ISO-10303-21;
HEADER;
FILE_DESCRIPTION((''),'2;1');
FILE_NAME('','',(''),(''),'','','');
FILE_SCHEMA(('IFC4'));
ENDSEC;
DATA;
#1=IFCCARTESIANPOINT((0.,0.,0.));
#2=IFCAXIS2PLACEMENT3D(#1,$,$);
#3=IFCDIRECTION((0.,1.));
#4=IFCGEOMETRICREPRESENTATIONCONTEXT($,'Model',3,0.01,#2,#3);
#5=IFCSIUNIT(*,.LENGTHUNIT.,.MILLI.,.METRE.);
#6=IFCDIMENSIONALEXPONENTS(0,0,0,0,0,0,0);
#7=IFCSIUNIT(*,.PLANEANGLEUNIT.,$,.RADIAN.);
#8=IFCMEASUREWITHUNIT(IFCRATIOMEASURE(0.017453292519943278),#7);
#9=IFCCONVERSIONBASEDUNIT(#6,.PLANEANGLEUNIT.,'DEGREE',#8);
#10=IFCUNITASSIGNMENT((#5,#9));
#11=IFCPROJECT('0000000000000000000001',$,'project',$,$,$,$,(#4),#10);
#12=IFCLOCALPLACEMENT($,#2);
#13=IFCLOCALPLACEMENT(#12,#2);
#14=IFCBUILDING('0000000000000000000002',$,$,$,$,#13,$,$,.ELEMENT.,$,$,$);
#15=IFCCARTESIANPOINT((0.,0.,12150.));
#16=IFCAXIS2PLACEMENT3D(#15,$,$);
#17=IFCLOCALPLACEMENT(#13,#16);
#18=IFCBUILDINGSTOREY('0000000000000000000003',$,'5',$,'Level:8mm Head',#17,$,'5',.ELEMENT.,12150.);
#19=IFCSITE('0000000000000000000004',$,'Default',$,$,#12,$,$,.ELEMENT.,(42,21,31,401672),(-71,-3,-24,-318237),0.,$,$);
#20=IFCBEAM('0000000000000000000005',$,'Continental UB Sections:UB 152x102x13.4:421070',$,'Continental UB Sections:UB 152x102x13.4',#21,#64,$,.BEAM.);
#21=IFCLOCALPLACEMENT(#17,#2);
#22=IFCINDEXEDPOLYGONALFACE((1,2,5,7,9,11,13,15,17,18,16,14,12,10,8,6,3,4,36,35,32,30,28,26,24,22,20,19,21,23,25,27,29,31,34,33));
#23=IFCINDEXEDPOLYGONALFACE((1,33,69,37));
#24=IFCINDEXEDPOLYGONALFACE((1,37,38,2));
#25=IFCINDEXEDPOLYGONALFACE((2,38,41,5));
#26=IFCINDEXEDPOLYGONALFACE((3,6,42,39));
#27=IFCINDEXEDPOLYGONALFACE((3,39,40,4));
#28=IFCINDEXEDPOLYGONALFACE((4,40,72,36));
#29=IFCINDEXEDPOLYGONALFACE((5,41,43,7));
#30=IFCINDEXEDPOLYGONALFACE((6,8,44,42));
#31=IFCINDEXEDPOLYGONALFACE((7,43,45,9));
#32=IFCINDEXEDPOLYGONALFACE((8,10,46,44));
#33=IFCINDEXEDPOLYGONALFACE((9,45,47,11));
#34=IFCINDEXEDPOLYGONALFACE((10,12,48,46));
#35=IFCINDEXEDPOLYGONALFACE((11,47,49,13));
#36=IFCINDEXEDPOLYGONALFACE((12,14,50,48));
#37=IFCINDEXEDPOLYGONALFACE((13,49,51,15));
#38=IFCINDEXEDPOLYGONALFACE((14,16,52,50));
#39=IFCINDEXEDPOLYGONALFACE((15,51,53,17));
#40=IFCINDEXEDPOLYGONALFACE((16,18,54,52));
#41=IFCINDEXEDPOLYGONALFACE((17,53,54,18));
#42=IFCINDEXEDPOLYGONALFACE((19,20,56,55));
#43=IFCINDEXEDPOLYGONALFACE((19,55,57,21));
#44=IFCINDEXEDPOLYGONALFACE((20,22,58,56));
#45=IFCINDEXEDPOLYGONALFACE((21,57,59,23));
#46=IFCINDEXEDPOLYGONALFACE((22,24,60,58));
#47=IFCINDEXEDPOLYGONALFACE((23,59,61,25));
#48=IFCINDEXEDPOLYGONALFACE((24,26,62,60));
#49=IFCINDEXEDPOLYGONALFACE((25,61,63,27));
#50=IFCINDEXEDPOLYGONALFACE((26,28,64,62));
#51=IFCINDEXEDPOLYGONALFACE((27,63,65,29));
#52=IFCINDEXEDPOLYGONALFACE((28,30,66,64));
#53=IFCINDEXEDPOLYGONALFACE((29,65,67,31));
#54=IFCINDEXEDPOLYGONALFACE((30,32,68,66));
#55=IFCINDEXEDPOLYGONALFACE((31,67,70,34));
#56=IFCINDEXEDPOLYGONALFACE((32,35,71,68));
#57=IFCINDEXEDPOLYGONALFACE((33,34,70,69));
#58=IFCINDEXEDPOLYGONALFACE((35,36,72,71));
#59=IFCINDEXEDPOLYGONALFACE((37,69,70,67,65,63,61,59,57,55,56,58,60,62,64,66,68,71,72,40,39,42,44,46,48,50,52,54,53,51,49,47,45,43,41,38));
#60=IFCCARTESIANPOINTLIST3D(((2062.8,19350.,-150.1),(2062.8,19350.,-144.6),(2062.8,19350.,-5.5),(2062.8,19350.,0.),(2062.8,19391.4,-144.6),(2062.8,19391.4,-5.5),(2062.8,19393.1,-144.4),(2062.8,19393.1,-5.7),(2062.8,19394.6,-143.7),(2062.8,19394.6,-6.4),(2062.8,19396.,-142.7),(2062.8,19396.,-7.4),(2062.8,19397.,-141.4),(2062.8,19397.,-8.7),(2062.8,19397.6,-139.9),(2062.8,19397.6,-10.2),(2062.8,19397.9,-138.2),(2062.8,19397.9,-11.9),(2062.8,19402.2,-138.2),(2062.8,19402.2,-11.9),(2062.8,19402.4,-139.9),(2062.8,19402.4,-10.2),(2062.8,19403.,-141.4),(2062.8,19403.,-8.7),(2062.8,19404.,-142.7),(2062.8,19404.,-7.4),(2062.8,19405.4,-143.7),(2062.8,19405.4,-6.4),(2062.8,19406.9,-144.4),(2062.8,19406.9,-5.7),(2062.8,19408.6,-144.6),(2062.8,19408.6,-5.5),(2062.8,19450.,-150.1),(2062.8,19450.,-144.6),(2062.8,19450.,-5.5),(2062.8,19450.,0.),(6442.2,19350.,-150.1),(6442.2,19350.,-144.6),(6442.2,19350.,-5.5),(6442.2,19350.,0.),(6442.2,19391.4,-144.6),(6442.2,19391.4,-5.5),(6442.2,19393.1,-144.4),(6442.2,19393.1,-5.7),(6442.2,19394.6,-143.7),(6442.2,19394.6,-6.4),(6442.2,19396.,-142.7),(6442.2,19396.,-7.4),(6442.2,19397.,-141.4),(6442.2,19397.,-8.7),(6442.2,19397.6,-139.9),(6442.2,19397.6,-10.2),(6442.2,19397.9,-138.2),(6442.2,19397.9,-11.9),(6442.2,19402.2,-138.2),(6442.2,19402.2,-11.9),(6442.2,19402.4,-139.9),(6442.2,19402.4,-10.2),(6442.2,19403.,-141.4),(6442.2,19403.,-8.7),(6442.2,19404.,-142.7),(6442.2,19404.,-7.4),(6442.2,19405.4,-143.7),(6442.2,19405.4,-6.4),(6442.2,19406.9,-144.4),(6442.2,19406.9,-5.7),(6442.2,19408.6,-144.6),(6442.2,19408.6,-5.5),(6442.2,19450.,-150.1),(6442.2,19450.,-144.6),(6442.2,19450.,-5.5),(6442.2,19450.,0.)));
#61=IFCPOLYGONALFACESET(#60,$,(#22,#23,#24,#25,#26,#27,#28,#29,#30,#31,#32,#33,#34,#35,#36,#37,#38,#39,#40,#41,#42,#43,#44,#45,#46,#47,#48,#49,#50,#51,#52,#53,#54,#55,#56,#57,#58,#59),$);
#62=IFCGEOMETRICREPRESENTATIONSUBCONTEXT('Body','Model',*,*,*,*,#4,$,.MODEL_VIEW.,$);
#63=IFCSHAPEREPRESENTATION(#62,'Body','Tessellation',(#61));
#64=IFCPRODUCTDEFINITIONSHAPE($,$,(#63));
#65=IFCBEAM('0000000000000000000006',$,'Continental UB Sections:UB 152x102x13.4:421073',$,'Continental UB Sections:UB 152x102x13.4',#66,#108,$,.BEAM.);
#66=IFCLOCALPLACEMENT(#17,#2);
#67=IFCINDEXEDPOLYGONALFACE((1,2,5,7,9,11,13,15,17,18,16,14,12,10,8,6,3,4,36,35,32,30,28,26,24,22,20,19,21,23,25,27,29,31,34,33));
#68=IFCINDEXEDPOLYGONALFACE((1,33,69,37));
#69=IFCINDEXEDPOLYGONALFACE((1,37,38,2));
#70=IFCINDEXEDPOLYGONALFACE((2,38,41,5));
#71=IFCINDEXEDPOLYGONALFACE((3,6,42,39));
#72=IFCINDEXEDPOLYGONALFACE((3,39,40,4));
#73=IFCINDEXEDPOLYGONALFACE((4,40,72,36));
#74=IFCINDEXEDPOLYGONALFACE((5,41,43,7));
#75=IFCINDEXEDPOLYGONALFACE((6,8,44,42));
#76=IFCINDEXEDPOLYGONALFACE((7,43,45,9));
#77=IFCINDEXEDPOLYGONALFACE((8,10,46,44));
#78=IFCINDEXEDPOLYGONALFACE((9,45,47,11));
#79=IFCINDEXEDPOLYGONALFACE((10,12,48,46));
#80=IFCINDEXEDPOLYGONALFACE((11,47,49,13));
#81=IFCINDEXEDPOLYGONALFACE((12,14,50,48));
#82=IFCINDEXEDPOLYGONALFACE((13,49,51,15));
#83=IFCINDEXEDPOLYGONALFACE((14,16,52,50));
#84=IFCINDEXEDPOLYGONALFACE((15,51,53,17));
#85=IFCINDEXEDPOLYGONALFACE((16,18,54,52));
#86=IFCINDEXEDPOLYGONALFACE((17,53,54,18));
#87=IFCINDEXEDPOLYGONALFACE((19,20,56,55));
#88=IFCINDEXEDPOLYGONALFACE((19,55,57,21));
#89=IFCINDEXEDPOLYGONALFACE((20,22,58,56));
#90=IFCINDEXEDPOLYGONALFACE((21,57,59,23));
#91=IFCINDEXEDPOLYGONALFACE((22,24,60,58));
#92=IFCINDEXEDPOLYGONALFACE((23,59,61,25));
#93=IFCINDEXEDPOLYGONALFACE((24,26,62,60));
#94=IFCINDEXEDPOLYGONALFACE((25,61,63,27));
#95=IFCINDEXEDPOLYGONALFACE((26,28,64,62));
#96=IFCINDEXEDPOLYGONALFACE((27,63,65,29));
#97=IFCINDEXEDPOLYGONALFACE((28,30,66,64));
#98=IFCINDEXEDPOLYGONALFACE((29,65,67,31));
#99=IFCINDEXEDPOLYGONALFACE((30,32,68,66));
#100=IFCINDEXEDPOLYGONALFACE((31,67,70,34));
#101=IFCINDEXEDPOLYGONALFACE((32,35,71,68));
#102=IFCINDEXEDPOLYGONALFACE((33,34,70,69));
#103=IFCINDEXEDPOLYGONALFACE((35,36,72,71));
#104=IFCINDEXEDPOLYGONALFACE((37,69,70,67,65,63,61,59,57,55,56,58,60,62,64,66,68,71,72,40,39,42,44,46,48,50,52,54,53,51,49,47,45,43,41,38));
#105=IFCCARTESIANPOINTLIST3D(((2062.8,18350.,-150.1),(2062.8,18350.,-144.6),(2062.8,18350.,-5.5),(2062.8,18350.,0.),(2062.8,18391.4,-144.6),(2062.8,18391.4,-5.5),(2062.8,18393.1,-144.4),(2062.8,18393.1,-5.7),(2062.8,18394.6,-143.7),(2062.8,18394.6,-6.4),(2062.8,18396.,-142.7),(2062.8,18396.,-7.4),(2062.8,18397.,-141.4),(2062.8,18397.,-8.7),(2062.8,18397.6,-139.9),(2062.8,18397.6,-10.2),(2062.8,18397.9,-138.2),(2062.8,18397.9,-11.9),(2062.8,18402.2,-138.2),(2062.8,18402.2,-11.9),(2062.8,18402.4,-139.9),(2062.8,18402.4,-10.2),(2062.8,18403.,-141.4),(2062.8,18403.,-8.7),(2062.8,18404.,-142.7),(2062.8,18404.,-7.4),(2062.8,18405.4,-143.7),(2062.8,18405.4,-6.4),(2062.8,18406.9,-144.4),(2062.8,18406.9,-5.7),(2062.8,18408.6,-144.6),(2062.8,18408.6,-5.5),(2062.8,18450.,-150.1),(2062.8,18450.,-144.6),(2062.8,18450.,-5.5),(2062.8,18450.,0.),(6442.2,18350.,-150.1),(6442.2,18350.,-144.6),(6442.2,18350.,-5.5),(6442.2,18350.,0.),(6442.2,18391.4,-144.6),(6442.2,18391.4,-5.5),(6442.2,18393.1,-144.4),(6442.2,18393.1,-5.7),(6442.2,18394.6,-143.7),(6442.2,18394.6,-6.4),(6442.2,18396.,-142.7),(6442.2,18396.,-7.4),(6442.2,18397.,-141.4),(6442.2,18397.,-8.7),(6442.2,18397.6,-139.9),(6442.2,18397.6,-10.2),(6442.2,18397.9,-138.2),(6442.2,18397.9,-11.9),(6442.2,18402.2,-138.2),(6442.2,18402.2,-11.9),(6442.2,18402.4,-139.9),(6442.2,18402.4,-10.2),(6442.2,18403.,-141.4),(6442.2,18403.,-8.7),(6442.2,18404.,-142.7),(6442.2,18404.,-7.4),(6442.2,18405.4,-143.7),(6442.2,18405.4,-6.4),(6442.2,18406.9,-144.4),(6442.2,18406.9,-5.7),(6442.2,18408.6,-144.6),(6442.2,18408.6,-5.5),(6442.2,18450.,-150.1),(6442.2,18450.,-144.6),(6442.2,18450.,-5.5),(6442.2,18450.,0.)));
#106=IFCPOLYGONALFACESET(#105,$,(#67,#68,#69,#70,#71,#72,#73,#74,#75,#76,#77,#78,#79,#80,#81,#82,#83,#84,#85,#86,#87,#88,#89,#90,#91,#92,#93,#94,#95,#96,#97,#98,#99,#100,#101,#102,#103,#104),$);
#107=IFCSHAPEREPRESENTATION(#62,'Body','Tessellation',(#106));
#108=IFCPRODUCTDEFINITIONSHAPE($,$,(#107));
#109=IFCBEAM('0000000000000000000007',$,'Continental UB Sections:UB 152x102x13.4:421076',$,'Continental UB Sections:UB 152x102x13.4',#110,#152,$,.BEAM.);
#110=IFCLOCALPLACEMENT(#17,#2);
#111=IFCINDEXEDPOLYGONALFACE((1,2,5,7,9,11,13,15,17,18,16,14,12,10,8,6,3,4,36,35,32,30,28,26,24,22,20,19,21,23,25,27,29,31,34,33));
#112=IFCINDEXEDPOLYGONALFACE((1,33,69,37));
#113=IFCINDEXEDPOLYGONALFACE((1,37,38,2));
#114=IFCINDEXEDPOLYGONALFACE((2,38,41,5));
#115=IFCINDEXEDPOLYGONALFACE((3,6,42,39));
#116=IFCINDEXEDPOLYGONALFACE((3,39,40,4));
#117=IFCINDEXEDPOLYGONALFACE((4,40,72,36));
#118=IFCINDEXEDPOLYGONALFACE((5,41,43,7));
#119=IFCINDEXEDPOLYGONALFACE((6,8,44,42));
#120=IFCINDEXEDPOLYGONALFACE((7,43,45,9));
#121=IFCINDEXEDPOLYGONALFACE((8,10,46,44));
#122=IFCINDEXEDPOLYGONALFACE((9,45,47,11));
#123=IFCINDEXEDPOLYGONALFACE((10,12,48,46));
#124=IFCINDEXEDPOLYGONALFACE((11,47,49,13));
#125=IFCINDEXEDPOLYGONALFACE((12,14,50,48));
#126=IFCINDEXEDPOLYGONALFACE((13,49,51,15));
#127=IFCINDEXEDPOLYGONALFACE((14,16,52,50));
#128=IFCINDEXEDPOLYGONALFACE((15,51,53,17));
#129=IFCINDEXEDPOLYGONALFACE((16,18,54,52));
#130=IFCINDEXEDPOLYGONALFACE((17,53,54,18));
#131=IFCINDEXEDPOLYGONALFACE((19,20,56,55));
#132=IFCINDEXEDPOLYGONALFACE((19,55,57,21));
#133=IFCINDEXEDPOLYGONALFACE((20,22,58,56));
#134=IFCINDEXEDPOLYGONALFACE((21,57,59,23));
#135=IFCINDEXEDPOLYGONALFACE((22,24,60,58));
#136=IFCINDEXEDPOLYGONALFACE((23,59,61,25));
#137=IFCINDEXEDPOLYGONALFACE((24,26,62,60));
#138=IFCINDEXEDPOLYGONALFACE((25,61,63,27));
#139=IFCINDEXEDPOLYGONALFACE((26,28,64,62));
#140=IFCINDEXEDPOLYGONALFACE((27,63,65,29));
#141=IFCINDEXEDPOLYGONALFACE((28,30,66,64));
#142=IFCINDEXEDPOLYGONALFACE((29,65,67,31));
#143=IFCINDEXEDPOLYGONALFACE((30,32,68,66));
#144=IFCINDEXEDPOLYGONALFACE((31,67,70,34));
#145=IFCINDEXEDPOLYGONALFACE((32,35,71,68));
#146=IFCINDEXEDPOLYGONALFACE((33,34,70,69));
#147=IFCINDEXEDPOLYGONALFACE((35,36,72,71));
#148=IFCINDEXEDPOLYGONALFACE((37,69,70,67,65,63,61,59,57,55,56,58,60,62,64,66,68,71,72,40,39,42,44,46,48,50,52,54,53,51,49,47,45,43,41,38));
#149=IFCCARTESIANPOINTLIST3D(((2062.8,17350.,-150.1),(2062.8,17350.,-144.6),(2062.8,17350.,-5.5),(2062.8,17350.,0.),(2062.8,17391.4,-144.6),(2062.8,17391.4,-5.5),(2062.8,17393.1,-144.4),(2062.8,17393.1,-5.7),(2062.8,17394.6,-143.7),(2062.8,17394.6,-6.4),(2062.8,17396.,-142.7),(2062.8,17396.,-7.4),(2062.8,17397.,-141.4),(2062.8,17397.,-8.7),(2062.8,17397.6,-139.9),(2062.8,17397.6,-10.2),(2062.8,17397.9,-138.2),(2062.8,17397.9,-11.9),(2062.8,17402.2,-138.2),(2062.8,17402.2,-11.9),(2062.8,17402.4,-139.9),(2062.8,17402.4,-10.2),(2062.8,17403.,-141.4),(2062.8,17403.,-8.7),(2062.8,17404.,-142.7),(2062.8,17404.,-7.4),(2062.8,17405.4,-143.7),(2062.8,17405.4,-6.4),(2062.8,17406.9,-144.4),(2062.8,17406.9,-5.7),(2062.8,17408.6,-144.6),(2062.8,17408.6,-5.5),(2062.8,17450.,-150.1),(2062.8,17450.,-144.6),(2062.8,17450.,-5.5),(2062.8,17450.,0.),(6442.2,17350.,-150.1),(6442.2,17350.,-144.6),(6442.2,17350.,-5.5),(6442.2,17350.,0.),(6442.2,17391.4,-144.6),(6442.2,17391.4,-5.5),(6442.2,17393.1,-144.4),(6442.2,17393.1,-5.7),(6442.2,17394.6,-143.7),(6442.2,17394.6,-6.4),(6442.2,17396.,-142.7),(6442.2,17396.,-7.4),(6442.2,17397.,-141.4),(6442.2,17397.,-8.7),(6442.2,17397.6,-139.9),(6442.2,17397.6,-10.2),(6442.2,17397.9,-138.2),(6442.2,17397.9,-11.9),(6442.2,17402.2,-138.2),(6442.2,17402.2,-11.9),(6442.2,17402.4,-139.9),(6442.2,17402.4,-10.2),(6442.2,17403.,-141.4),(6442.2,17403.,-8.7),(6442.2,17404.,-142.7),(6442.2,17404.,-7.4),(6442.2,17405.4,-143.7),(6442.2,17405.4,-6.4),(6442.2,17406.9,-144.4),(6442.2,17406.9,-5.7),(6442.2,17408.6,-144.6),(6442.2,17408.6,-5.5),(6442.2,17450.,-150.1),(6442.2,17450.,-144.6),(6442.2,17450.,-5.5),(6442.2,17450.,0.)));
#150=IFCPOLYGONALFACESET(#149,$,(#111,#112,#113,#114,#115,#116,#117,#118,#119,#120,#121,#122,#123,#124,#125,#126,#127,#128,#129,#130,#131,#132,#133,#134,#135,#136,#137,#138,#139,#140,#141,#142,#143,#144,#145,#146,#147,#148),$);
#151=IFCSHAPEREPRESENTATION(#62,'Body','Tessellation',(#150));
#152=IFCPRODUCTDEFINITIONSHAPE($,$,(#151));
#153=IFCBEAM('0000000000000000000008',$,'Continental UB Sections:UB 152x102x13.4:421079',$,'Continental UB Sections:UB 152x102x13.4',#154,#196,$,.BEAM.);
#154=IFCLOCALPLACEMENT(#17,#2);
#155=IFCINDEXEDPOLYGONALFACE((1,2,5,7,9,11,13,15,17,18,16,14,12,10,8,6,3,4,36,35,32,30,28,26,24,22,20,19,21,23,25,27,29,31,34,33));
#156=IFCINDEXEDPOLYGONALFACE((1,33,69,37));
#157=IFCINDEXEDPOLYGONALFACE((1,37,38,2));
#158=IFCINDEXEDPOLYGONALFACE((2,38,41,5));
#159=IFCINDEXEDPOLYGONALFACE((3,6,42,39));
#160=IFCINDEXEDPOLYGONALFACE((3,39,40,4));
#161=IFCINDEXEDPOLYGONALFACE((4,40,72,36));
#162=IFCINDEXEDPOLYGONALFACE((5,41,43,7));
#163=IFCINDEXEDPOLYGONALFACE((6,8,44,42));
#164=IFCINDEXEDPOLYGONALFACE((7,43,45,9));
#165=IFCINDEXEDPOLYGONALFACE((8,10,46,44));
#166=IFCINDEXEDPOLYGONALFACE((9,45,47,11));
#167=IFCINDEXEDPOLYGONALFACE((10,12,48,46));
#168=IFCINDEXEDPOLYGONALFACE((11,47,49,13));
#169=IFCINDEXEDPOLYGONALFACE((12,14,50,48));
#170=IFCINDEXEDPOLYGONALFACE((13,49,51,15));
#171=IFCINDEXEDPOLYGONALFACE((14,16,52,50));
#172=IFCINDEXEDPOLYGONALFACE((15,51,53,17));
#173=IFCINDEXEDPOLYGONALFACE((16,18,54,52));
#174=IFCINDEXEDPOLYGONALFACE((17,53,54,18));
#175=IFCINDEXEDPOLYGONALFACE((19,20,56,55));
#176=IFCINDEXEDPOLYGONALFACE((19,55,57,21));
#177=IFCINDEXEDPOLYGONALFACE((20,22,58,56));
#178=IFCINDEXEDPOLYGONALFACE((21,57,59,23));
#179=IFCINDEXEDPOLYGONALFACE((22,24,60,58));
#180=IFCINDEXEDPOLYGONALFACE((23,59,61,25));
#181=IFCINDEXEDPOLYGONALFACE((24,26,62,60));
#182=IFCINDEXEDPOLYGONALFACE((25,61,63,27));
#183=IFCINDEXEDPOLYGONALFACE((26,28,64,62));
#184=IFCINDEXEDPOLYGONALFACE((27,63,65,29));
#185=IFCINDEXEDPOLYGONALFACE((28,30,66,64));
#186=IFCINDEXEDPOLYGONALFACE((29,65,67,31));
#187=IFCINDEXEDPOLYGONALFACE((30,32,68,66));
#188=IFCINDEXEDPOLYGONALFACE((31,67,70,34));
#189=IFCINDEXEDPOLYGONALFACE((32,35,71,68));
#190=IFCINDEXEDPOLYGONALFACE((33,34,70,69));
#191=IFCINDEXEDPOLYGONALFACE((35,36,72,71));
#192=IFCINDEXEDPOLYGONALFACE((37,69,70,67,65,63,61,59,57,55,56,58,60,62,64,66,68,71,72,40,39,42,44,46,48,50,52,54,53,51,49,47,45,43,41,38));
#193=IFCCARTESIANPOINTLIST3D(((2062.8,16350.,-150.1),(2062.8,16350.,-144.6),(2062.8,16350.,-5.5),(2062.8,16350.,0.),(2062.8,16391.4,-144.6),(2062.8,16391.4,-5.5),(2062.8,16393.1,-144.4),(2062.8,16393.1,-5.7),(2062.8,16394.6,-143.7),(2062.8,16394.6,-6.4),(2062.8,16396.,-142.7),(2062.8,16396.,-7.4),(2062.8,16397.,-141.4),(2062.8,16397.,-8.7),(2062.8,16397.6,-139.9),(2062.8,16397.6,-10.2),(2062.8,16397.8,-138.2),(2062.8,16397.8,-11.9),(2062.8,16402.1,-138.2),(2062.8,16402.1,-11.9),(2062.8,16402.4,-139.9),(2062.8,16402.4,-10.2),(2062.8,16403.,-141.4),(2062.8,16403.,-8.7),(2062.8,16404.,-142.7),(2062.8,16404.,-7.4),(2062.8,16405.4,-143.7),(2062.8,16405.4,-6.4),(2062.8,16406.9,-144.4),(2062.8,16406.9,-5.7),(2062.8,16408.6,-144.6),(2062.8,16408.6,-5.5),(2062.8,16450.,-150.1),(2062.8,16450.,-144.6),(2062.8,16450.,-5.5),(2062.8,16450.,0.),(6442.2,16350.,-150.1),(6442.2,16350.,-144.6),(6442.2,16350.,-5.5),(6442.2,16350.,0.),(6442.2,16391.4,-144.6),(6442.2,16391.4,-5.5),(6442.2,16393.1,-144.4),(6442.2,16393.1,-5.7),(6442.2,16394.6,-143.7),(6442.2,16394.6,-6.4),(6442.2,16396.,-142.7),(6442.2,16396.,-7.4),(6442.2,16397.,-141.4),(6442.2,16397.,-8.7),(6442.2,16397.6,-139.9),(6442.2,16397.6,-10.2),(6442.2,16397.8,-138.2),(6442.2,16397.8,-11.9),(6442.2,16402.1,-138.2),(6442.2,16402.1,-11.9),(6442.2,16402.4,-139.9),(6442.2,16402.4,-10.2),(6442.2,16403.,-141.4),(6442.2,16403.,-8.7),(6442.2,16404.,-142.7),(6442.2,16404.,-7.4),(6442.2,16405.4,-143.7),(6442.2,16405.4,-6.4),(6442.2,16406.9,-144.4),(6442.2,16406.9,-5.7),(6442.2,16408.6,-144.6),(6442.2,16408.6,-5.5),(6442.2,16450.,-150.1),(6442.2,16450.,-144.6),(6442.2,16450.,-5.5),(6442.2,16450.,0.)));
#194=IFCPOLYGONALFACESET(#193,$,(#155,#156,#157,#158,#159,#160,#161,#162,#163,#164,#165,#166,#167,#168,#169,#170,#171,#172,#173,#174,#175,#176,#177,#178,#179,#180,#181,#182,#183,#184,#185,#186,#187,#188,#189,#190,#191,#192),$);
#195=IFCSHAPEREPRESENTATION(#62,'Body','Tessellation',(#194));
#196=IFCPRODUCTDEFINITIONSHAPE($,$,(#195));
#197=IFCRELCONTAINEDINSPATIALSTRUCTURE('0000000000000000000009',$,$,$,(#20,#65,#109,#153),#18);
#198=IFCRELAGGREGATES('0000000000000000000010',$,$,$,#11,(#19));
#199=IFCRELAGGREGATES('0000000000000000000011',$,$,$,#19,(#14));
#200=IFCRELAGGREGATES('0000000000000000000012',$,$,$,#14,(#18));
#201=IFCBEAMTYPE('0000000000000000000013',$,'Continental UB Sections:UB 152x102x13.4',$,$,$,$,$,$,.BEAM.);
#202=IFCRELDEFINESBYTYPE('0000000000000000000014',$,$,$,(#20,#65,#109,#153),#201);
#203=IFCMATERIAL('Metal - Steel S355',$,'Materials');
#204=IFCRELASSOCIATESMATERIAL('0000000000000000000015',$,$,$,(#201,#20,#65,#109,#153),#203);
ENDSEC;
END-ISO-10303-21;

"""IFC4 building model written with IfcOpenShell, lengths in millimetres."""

from ifc_helpers import new_model, entity, si_unit, converted_unit, direction, frame, origin, place, context, subcontext, project, spatial, line, arc, indexed_curve, outline, extrude, source, transform, mapped, material, type_object, type_shapes, element, save


model = new_model("IFC4")

# Units and contexts
model_context = context("Model", 3, precision=0.01, world=origin(), true_north=direction((0.0, 1.0)))
body_context = subcontext(model_context, "Body", "Model", "MODEL_VIEW")
ifc_project = project(units=[si_unit("LENGTHUNIT", "METRE", prefix="MILLI"), converted_unit("PLANEANGLEUNIT", "DEGREE", entity("IfcRatioMeasure", 0.017453292519943278), si_unit("PLANEANGLEUNIT", "RADIAN"), dimensions=[0, 0, 0, 0, 0, 0, 0])], contexts=[model_context])

# Site, building, storey
site_placement = place(None, origin())
site = spatial("IfcSite", under=ifc_project, at=site_placement, Name="Default", CompositionType="ELEMENT", RefLatitude=(42, 21, 31, 401672), RefLongitude=(-71, -3, -24, -318237), RefElevation=0.0)
building_placement = place(site_placement, origin())
building = spatial("IfcBuilding", under=site, at=building_placement, CompositionType="ELEMENT")
storey_placement = place(building_placement, frame((0.0, 0.0, 12150.0)))
storey = spatial("IfcBuildingStorey", under=building, at=storey_placement, Name="5", ObjectType="Level:8mm Head", LongName="5", CompositionType="ELEMENT", Elevation=12150.0)

# Beams
ifc_material = material(Name="Metal - Steel S355", Category="Materials")
beam_type_1 = type_object("IfcBeamType", Name="Continental UB Sections:UB 152x102x13.4", PredefinedType="BEAM", material=ifc_material)
shared_shape_1 = source(origin(), body_context, "Body", "SweptSolid", [
    extrude(outline(indexed_curve([(-75.0, -50.1), (-69.6, -50.1), (-69.6, -8.5), (-67.7, -4.0), (-63.2, -2.1), (63.1, -2.1), (67.7, -4.0), (69.5, -8.5), (69.5, -50.1), (75.1, -50.1), (75.1, 50.1), (69.5, 50.1), (69.5, 8.6), (67.7, 4.0), (63.1, 2.2), (-63.2, 2.2), (-67.7, 4.0), (-69.6, 8.6), (-69.6, 50.0), (-75.0, 50.0)], segments=[line(1, 2, 3), arc(3, 4, 5), line(5, 6), arc(6, 7, 8), line(8, 9, 10, 11, 12, 13), arc(13, 14, 15), line(15, 16), arc(16, 17, 18), line(18, 19, 20, 1)], self_intersect=False)), frame((-2189.7, 0.0, 0.0), z_axis=(1.0, 0.0, 0.0), x_axis=(0.0, 0.0, -1.0)), (0.0, 0.0, 1.0), 4379.4),
])
type_shapes(beam_type_1, [shared_shape_1])
for number, where, name in (
    (1, (4252.5, 19400.0, -75.1), "Continental UB Sections:UB 152x102x13.4:421070"),
    (2, (4252.5, 18400.0, -75.1), "Continental UB Sections:UB 152x102x13.4:421073"),
    (3, (4252.5, 17400.0, -75.1), "Continental UB Sections:UB 152x102x13.4:421076"),
    (4, (4252.5, 16400.0, -75.1), "Continental UB Sections:UB 152x102x13.4:421079"),
):
    element("IfcBeam", number, at=place(storey_placement, frame(where)), inside=storey, type_object=beam_type_1, material=ifc_material, Name=name, ObjectType="Continental UB Sections:UB 152x102x13.4", PredefinedType="BEAM", context=body_context, shape_type="MappedRepresentation", body=[
        mapped(shared_shape_1, transform((0.0, 0.0, 0.0), scale=1.0)),
    ])

save(model, "model.ifc")
